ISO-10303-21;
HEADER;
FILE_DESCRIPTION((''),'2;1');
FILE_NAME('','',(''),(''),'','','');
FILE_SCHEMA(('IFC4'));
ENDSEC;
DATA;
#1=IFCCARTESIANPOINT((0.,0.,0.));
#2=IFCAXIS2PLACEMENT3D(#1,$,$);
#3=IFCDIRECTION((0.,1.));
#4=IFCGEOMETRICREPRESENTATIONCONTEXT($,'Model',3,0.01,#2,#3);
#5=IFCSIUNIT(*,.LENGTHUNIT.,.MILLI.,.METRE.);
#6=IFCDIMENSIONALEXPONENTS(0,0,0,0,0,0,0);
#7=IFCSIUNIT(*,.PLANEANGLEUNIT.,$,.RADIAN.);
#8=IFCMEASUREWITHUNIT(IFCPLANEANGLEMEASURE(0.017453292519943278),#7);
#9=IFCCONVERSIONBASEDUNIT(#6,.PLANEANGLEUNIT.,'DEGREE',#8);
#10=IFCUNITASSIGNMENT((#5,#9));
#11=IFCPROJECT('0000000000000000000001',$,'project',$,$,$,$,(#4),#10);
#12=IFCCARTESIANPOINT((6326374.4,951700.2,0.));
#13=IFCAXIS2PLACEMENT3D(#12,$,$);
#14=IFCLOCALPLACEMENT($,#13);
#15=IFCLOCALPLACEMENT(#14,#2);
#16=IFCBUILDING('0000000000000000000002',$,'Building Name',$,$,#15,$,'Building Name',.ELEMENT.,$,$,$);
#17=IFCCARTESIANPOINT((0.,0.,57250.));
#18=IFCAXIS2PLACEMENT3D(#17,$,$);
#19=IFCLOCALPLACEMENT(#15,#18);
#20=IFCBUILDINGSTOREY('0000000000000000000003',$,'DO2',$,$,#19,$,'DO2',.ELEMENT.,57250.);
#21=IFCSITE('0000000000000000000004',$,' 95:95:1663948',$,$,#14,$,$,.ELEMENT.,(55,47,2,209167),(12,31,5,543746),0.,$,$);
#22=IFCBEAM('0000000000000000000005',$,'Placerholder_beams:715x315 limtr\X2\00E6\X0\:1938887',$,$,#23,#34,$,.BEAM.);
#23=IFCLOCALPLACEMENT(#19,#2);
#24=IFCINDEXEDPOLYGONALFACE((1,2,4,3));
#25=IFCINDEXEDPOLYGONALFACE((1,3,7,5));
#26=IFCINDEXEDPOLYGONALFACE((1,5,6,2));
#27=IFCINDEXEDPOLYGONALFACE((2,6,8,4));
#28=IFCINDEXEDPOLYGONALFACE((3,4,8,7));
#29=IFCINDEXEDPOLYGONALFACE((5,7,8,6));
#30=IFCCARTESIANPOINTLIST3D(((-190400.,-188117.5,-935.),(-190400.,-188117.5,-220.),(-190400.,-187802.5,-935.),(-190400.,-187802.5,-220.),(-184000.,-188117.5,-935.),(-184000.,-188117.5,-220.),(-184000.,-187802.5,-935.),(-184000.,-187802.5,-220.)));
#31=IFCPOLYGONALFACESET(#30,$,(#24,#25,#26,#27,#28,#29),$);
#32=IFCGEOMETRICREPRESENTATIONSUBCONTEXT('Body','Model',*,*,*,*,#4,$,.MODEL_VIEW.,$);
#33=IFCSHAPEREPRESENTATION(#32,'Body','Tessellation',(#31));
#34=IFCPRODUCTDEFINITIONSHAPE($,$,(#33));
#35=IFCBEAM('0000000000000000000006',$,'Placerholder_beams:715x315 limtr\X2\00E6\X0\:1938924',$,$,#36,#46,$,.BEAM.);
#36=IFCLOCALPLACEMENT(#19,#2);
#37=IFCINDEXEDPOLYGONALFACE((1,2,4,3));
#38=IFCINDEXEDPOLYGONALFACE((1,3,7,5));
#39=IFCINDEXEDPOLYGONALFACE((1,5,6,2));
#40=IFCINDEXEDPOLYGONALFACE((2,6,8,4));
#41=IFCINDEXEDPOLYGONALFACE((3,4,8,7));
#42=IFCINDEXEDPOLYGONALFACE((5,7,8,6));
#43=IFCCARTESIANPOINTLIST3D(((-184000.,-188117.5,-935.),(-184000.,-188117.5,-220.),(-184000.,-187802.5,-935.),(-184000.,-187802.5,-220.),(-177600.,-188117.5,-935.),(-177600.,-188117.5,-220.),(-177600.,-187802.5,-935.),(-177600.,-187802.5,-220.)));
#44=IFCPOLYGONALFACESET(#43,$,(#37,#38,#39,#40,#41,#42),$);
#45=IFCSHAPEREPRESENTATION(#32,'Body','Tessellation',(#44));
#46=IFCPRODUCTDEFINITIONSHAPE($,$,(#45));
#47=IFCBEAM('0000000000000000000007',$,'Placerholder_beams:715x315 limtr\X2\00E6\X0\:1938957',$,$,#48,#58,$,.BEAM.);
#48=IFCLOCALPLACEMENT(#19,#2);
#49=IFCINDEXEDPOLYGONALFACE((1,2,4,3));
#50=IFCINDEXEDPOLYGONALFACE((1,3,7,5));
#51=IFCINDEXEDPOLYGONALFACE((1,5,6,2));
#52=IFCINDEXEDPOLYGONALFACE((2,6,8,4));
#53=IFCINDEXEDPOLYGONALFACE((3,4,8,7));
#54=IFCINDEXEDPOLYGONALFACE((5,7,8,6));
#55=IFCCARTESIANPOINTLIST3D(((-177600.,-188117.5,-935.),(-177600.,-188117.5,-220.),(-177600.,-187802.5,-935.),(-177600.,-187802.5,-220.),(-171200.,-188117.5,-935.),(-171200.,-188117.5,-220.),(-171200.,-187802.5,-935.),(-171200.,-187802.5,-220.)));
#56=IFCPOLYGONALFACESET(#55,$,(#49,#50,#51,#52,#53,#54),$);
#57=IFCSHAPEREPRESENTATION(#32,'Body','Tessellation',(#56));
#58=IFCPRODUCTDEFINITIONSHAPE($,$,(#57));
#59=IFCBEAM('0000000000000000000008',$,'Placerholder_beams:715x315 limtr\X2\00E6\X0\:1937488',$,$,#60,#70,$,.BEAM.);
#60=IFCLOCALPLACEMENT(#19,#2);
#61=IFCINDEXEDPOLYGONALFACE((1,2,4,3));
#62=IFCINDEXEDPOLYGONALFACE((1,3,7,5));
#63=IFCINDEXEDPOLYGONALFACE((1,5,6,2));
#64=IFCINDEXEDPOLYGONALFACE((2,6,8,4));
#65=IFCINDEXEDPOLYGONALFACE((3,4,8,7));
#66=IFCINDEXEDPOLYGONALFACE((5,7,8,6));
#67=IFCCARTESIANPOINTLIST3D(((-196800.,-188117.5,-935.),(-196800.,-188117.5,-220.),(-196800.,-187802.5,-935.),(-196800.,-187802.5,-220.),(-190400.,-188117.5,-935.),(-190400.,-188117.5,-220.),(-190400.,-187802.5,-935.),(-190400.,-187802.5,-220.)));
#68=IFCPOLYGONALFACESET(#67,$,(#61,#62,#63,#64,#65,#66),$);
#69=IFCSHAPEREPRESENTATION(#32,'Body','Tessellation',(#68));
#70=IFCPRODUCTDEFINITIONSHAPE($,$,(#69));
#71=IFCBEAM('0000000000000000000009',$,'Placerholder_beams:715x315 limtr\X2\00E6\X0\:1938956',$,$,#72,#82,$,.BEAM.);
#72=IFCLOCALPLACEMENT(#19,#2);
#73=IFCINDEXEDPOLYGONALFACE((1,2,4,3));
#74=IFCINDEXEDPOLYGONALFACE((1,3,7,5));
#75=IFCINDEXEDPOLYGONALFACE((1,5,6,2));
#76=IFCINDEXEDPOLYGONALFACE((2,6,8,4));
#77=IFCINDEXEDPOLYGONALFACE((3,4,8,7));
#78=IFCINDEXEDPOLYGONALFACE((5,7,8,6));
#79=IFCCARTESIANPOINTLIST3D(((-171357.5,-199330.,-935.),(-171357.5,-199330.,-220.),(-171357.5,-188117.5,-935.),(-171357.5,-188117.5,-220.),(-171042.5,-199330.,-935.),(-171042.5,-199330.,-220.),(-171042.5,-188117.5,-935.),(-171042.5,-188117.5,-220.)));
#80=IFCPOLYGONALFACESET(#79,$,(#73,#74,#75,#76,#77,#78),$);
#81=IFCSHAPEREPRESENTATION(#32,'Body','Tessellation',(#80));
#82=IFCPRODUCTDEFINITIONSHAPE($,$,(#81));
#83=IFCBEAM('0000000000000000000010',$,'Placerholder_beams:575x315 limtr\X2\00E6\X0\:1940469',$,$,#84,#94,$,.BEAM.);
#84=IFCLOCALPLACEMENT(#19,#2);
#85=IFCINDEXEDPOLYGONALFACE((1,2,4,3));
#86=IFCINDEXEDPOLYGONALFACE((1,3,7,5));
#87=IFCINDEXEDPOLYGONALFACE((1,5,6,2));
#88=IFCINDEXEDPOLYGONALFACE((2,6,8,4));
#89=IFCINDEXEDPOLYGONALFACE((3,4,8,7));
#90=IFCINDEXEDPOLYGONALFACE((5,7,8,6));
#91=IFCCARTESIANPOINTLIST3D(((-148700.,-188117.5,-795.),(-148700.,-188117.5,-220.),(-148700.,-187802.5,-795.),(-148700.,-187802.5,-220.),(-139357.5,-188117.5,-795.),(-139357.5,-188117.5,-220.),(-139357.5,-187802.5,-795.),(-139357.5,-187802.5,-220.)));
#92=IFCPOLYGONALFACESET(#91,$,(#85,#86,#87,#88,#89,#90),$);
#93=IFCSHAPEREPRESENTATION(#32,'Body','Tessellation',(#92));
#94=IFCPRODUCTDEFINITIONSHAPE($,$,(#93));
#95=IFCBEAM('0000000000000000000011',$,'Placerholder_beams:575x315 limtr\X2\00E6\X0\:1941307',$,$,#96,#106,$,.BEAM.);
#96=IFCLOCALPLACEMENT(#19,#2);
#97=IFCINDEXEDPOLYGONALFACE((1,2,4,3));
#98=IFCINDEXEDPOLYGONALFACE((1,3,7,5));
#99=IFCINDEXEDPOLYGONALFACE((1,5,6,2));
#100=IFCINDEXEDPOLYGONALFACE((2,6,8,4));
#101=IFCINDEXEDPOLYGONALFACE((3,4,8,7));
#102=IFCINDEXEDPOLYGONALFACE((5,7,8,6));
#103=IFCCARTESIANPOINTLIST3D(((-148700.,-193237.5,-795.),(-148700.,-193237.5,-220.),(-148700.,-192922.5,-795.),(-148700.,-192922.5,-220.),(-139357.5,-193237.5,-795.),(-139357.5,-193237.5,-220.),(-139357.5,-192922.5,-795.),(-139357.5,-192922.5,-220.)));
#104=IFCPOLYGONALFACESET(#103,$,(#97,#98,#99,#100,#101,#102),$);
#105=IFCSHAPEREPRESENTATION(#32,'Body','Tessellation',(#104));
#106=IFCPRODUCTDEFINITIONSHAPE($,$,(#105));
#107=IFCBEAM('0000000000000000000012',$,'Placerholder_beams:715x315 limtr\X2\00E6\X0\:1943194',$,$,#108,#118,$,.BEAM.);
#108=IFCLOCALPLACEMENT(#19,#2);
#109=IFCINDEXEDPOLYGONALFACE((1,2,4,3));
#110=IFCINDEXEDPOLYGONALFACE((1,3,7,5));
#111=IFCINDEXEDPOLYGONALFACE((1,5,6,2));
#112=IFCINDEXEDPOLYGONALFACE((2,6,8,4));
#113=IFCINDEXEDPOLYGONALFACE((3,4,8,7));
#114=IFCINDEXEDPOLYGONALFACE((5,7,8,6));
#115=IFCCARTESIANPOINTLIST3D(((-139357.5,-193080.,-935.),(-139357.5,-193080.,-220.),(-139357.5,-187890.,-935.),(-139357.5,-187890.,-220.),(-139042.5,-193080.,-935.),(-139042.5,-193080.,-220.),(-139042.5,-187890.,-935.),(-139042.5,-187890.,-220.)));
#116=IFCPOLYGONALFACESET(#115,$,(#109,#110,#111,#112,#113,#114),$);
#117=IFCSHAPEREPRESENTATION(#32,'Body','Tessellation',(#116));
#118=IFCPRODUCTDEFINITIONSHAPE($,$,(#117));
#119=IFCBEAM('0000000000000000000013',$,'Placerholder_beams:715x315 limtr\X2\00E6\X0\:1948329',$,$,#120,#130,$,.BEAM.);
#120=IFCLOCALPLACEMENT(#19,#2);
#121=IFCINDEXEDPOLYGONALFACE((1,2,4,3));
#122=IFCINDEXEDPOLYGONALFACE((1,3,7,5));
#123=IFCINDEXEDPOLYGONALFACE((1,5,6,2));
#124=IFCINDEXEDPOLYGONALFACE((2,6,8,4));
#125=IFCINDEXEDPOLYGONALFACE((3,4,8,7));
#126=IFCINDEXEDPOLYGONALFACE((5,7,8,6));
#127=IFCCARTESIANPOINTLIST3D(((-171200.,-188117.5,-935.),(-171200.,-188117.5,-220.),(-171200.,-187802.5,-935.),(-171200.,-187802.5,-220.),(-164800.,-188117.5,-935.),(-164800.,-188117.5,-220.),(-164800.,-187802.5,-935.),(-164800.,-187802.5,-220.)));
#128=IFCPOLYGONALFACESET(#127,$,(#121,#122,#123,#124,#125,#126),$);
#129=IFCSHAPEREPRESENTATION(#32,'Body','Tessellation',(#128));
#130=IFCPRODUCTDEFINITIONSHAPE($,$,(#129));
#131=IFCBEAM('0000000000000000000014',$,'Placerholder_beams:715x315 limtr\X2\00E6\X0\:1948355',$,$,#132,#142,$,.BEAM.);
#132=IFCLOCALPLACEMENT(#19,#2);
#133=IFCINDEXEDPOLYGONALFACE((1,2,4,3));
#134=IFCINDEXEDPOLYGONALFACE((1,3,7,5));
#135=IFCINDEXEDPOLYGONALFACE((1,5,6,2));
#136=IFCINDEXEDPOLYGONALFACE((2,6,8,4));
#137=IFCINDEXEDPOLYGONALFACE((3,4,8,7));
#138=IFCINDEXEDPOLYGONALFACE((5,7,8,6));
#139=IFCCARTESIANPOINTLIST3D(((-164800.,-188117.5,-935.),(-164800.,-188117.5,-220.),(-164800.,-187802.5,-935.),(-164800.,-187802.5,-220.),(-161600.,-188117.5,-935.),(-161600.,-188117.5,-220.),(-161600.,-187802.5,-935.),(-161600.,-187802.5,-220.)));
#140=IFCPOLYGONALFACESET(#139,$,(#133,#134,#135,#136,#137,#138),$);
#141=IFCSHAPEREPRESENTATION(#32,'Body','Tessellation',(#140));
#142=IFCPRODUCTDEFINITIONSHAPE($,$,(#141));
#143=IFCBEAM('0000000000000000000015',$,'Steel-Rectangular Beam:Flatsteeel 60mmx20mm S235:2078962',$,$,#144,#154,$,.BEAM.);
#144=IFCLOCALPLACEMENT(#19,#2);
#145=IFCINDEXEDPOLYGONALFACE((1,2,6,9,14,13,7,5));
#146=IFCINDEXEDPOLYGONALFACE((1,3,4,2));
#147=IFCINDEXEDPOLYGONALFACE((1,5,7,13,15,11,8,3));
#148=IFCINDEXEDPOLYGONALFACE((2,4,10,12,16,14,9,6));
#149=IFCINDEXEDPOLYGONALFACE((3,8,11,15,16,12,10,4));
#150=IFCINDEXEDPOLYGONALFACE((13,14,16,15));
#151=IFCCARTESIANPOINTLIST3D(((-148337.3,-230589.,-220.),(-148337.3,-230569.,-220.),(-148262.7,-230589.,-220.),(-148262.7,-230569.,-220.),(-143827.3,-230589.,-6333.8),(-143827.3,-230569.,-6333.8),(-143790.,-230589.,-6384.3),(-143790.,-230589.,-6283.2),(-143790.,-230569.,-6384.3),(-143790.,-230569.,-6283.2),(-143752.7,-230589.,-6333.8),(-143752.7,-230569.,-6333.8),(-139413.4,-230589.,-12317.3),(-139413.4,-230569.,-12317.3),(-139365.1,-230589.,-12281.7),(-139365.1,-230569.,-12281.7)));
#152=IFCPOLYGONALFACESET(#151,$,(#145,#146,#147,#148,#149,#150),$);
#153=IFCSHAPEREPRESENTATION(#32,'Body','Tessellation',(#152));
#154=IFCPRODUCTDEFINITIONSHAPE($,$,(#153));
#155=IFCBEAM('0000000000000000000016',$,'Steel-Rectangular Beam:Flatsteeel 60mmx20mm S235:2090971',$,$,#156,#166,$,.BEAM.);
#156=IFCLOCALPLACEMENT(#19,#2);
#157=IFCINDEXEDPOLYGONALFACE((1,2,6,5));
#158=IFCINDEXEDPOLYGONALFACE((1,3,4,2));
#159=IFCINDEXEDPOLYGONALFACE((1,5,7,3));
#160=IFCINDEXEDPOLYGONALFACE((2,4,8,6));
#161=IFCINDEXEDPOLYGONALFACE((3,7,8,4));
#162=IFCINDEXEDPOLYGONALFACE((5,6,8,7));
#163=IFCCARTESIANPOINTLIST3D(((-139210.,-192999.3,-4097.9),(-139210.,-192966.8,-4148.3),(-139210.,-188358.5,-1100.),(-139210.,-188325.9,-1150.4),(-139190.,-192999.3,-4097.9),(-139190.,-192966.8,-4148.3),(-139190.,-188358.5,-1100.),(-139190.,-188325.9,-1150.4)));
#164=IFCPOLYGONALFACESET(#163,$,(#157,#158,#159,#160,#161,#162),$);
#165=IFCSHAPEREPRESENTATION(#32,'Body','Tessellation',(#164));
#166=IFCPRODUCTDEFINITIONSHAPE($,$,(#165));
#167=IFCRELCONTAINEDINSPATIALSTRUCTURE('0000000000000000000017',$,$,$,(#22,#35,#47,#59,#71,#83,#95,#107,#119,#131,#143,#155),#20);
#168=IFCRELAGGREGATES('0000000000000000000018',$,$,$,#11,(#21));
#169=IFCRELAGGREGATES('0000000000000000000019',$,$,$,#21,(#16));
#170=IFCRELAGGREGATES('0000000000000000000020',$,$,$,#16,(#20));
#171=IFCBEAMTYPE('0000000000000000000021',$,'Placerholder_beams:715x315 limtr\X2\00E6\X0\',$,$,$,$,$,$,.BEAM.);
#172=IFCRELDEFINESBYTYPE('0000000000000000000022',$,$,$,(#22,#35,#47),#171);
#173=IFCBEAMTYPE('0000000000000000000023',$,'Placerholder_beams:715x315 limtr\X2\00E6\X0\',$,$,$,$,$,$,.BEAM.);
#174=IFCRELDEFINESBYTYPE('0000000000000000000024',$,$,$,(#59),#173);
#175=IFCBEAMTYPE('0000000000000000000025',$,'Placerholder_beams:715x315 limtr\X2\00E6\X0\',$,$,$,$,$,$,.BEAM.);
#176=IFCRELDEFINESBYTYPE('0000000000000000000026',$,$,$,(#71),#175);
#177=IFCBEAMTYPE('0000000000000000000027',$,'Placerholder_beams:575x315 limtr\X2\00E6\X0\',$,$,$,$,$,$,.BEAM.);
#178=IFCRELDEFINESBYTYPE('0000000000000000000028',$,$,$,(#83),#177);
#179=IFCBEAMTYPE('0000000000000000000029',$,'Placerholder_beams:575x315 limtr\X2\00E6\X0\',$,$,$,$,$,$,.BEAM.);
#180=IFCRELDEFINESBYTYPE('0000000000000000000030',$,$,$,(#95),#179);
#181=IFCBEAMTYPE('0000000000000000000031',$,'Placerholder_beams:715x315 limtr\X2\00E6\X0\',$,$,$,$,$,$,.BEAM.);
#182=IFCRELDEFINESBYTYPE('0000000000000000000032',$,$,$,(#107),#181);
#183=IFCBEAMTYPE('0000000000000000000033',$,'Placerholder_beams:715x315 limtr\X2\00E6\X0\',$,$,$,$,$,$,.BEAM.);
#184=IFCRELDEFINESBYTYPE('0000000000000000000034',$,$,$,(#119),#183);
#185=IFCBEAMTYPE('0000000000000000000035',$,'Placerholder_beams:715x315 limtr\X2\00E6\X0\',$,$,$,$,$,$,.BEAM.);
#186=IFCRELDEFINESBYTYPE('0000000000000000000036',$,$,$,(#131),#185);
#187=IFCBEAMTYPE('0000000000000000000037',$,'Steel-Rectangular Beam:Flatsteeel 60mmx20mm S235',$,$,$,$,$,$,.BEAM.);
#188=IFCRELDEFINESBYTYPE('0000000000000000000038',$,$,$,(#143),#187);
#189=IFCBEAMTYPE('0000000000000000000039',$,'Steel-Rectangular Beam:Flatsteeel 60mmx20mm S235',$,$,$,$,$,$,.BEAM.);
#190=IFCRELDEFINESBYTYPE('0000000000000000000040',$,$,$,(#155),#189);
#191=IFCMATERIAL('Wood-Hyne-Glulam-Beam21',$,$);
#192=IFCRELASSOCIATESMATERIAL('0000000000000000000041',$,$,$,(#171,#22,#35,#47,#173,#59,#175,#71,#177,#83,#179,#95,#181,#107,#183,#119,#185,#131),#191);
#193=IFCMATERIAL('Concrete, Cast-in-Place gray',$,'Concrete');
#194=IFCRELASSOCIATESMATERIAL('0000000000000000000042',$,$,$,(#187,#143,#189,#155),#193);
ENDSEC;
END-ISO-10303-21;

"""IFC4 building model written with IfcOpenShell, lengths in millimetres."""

from ifc_helpers import new_model, entity, si_unit, converted_unit, direction, frame, origin, place, context, subcontext, project, spatial, indexed_curve, outline, extrude, source, transform, mapped, material, type_object, type_shapes, element, save


model = new_model("IFC4")

# Units and contexts
model_context = context("Model", 3, precision=0.01, world=origin(), true_north=direction((0.0, 1.0)))
body_context = subcontext(model_context, "Body", "Model", "MODEL_VIEW")
ifc_project = project(units=[si_unit("LENGTHUNIT", "METRE", prefix="MILLI"), converted_unit("PLANEANGLEUNIT", "DEGREE", entity("IfcPlaneAngleMeasure", 0.017453292519943278), si_unit("PLANEANGLEUNIT", "RADIAN"), dimensions=[0, 0, 0, 0, 0, 0, 0])], contexts=[model_context])

# Site, building, storey
site_placement = place(None, frame((6326374.4, 951700.2, 0.0)))
site = spatial("IfcSite", under=ifc_project, at=site_placement, Name=" 95:95:1663948", CompositionType="ELEMENT", RefLatitude=(55, 47, 2, 209167), RefLongitude=(12, 31, 5, 543746), RefElevation=0.0)
building_placement = place(site_placement, origin())
building = spatial("IfcBuilding", under=site, at=building_placement, Name="Building Name", LongName="Building Name", CompositionType="ELEMENT")
storey_placement = place(building_placement, frame((0.0, 0.0, 57250.0)))
storey = spatial("IfcBuildingStorey", under=building, at=storey_placement, Name="DO2", LongName="DO2", CompositionType="ELEMENT", Elevation=57250.0)

# Beams
ifc_material_1 = material(Name="Wood-Hyne-Glulam-Beam21")
beam_type_1 = type_object("IfcBeamType", Name="Placerholder_beams:715x315 limtræ", PredefinedType="BEAM", material=ifc_material_1)
shared_shape_1 = source(origin(), body_context, "Body", "SweptSolid", [
    extrude(outline(indexed_curve([(-3200.0, -157.5), (3200.0, -157.5), (3200.0, 157.5), (-3200.0, 157.5), (-3200.0, -157.5)], self_intersect=False)), frame((0.0, 0.0, -357.5)), (0.0, 0.0, 1.0), 715.0),
])
type_shapes(beam_type_1, [shared_shape_1])
for number, where, name in (
    (1, (-187200.0, -187960.0, -577.5), "Placerholder_beams:715x315 limtræ:1938887"),
    (2, (-180800.0, -187960.0, -577.5), "Placerholder_beams:715x315 limtræ:1938924"),
    (3, (-174400.0, -187960.0, -577.5), "Placerholder_beams:715x315 limtræ:1938957"),
):
    element("IfcBeam", number, at=place(storey_placement, frame(where)), inside=storey, type_object=beam_type_1, material=ifc_material_1, Name=name, PredefinedType="BEAM", context=body_context, shape_type="MappedRepresentation", body=[
        mapped(shared_shape_1, transform((0.0, 0.0, 0.0), scale=1.0)),
    ])
beam_type_2 = type_object("IfcBeamType", Name="Placerholder_beams:715x315 limtræ", PredefinedType="BEAM", material=ifc_material_1)
shared_shape_2 = source(origin(), body_context, "Body", "SweptSolid", [
    extrude(outline(indexed_curve([(-3200.0, -157.5), (3200.0, -157.5), (3200.0, 157.5), (-3200.0, 157.5), (-3200.0, -157.5)], self_intersect=False)), frame((50.0, 0.0, -357.5)), (0.0, 0.0, 1.0), 715.0),
])
type_shapes(beam_type_2, [shared_shape_2])
beam_1_placement = place(storey_placement, frame((-193650.0, -187960.0, -577.5)))
element("IfcBeam", 4, at=beam_1_placement, inside=storey, type_object=beam_type_2, material=ifc_material_1, Name="Placerholder_beams:715x315 limtræ:1937488", PredefinedType="BEAM", context=body_context, shape_type="MappedRepresentation", body=[
    mapped(shared_shape_2, transform((0.0, 0.0, 0.0), scale=1.0)),
])
beam_type_3 = type_object("IfcBeamType", Name="Placerholder_beams:715x315 limtræ", PredefinedType="BEAM", material=ifc_material_1)
shared_shape_3 = source(origin(), body_context, "Body", "SweptSolid", [
    extrude(outline(indexed_curve([(-5606.3, -157.5), (5606.3, -157.5), (5606.3, 157.5), (-5606.3, 157.5), (-5606.3, -157.5)], self_intersect=False)), frame((-1603.8, 0.0, -357.5)), (0.0, 0.0, 1.0), 715.0),
])
type_shapes(beam_type_3, [shared_shape_3])
beam_2_placement = place(storey_placement, frame((-171200.0, -192120.0, -577.5), z_axis=(0.0, 0.0, 1.0), x_axis=(0.0, 1.0, 0.0)))
element("IfcBeam", 5, at=beam_2_placement, inside=storey, type_object=beam_type_3, material=ifc_material_1, Name="Placerholder_beams:715x315 limtræ:1938956", PredefinedType="BEAM", context=body_context, shape_type="MappedRepresentation", body=[
    mapped(shared_shape_3, transform((0.0, 0.0, 0.0), scale=1.0)),
])
beam_type_4 = type_object("IfcBeamType", Name="Placerholder_beams:575x315 limtræ", PredefinedType="BEAM", material=ifc_material_1)
shared_shape_4 = source(origin(), body_context, "Body", "SweptSolid", [
    extrude(outline(indexed_curve([(-4671.3, -157.5), (4671.3, -157.5), (4671.3, 157.5), (-4671.3, 157.5), (-4671.3, -157.5)], self_intersect=False)), frame((28.8, 0.0, -287.5)), (0.0, 0.0, 1.0), 575.0),
])
type_shapes(beam_type_4, [shared_shape_4])
beam_3_placement = place(storey_placement, frame((-144000.0, -187960.0, -507.5), z_axis=(0.0, 0.0, 1.0), x_axis=(-1.0, 0.0, 0.0)))
element("IfcBeam", 6, at=beam_3_placement, inside=storey, type_object=beam_type_4, material=ifc_material_1, Name="Placerholder_beams:575x315 limtræ:1940469", PredefinedType="BEAM", context=body_context, shape_type="MappedRepresentation", body=[
    mapped(shared_shape_4, transform((0.0, 0.0, 0.0), scale=1.0)),
])
beam_type_5 = type_object("IfcBeamType", Name="Placerholder_beams:575x315 limtræ", PredefinedType="BEAM", material=ifc_material_1)
shared_shape_5 = source(origin(), body_context, "Body", "SweptSolid", [
    extrude(outline(indexed_curve([(-4671.3, -157.5), (4671.3, -157.5), (4671.3, 157.5), (-4671.3, 157.5), (-4671.3, -157.5)], self_intersect=False)), frame((-28.7, 0.0, -287.5)), (0.0, 0.0, 1.0), 575.0),
])
type_shapes(beam_type_5, [shared_shape_5])
beam_4_placement = place(storey_placement, frame((-144000.0, -193080.0, -507.5)))
element("IfcBeam", 7, at=beam_4_placement, inside=storey, type_object=beam_type_5, material=ifc_material_1, Name="Placerholder_beams:575x315 limtræ:1941307", PredefinedType="BEAM", context=body_context, shape_type="MappedRepresentation", body=[
    mapped(shared_shape_5, transform((0.0, 0.0, 0.0), scale=1.0)),
])
beam_type_6 = type_object("IfcBeamType", Name="Placerholder_beams:715x315 limtræ", PredefinedType="BEAM", material=ifc_material_1)
shared_shape_6 = source(origin(), body_context, "Body", "SweptSolid", [
    extrude(outline(indexed_curve([(-2595.0, -157.5), (2595.0, -157.5), (2595.0, 157.5), (-2595.0, 157.5), (-2595.0, -157.5)], self_intersect=False)), frame((35.0, 0.0, -357.5)), (0.0, 0.0, 1.0), 715.0),
])
type_shapes(beam_type_6, [shared_shape_6])
beam_5_placement = place(storey_placement, frame((-139200.0, -190520.0, -577.5), z_axis=(0.0, 0.0, 1.0), x_axis=(0.0, 1.0, 0.0)))
element("IfcBeam", 8, at=beam_5_placement, inside=storey, type_object=beam_type_6, material=ifc_material_1, Name="Placerholder_beams:715x315 limtræ:1943194", PredefinedType="BEAM", context=body_context, shape_type="MappedRepresentation", body=[
    mapped(shared_shape_6, transform((0.0, 0.0, 0.0), scale=1.0)),
])
beam_type_7 = type_object("IfcBeamType", Name="Placerholder_beams:715x315 limtræ", PredefinedType="BEAM", material=ifc_material_1)
shared_shape_7 = source(origin(), body_context, "Body", "SweptSolid", [
    extrude(outline(indexed_curve([(-3200.0, -157.5), (3200.0, -157.5), (3200.0, 157.5), (-3200.0, 157.5), (-3200.0, -157.5)], self_intersect=False)), frame((0.0, 0.0, -357.5)), (0.0, 0.0, 1.0), 715.0),
])
type_shapes(beam_type_7, [shared_shape_7])
beam_6_placement = place(storey_placement, frame((-168000.0, -187960.0, -577.5)))
element("IfcBeam", 9, at=beam_6_placement, inside=storey, type_object=beam_type_7, material=ifc_material_1, Name="Placerholder_beams:715x315 limtræ:1948329", PredefinedType="BEAM", context=body_context, shape_type="MappedRepresentation", body=[
    mapped(shared_shape_7, transform((0.0, 0.0, 0.0), scale=1.0)),
])
beam_type_8 = type_object("IfcBeamType", Name="Placerholder_beams:715x315 limtræ", PredefinedType="BEAM", material=ifc_material_1)
shared_shape_8 = source(origin(), body_context, "Body", "SweptSolid", [
    extrude(outline(indexed_curve([(-1600.0, -157.5), (1600.0, -157.5), (1600.0, 157.5), (-1600.0, 157.5), (-1600.0, -157.5)], self_intersect=False)), frame((-50.0, 0.0, -357.5)), (0.0, 0.0, 1.0), 715.0),
])
type_shapes(beam_type_8, [shared_shape_8])
beam_7_placement = place(storey_placement, frame((-163150.0, -187960.0, -577.5)))
element("IfcBeam", 10, at=beam_7_placement, inside=storey, type_object=beam_type_8, material=ifc_material_1, Name="Placerholder_beams:715x315 limtræ:1948355", PredefinedType="BEAM", context=body_context, shape_type="MappedRepresentation", body=[
    mapped(shared_shape_8, transform((0.0, 0.0, 0.0), scale=1.0)),
])
ifc_material_2 = material(Name="Concrete, Cast-in-Place gray", Category="Concrete")
beam_type_9 = type_object("IfcBeamType", Name="Steel-Rectangular Beam:Flatsteeel 60mmx20mm S235", PredefinedType="BEAM", material=ifc_material_2)
shared_shape_9 = source(origin(), body_context, "Body", "SweptSolid", [
    extrude(outline(indexed_curve([(-7459.3, -30.0), (-86.7, -30.0), (-23.9, -30.0), (7573.4, -30.0), (7529.1, 30.0), (-5.3, 30.0), (-68.1, 30.0), (-7459.3, 30.0), (-7459.3, -30.0)], self_intersect=False)), frame((-143817.3, -230589.0, 50953.3), z_axis=(0.0, 1.0, 0.0), x_axis=(-0.593635, 0.0, 0.804734)), (0.0, 0.0, 1.0), 20.0),
])
type_shapes(beam_type_9, [shared_shape_9])
beam_8_placement = place(storey_placement, frame((0.0, 0.0, -57250.0)))
element("IfcBeam", 11, at=beam_8_placement, inside=storey, type_object=beam_type_9, material=ifc_material_2, Name="Steel-Rectangular Beam:Flatsteeel 60mmx20mm S235:2078962", PredefinedType="BEAM", context=body_context, shape_type="MappedRepresentation", body=[
    mapped(shared_shape_9, transform((0.0, 0.0, 0.0), scale=1.0)),
])
beam_type_10 = type_object("IfcBeamType", Name="Steel-Rectangular Beam:Flatsteeel 60mmx20mm S235", PredefinedType="BEAM", material=ifc_material_2)
shared_shape_10 = source(origin(), body_context, "Body", "SweptSolid", [
    extrude(outline(indexed_curve([(-30.0, -10.0), (30.0, -10.0), (30.0, 10.0), (-30.0, 10.0), (-30.0, -10.0)], self_intersect=False)), frame((-139200.0, -188342.2, 56124.8), z_axis=(0.0, -0.839983, -0.542612), x_axis=(0.0, 0.542612, -0.839983)), (0.0, 0.0, 1.0), 5524.9),
])
type_shapes(beam_type_10, [shared_shape_10])
beam_9_placement = place(storey_placement, frame((0.0, 0.0, -57250.0)))
element("IfcBeam", 12, at=beam_9_placement, inside=storey, type_object=beam_type_10, material=ifc_material_2, Name="Steel-Rectangular Beam:Flatsteeel 60mmx20mm S235:2090971", PredefinedType="BEAM", context=body_context, shape_type="MappedRepresentation", body=[
    mapped(shared_shape_10, transform((0.0, 0.0, 0.0), scale=1.0)),
])

save(model, "model.ifc")
